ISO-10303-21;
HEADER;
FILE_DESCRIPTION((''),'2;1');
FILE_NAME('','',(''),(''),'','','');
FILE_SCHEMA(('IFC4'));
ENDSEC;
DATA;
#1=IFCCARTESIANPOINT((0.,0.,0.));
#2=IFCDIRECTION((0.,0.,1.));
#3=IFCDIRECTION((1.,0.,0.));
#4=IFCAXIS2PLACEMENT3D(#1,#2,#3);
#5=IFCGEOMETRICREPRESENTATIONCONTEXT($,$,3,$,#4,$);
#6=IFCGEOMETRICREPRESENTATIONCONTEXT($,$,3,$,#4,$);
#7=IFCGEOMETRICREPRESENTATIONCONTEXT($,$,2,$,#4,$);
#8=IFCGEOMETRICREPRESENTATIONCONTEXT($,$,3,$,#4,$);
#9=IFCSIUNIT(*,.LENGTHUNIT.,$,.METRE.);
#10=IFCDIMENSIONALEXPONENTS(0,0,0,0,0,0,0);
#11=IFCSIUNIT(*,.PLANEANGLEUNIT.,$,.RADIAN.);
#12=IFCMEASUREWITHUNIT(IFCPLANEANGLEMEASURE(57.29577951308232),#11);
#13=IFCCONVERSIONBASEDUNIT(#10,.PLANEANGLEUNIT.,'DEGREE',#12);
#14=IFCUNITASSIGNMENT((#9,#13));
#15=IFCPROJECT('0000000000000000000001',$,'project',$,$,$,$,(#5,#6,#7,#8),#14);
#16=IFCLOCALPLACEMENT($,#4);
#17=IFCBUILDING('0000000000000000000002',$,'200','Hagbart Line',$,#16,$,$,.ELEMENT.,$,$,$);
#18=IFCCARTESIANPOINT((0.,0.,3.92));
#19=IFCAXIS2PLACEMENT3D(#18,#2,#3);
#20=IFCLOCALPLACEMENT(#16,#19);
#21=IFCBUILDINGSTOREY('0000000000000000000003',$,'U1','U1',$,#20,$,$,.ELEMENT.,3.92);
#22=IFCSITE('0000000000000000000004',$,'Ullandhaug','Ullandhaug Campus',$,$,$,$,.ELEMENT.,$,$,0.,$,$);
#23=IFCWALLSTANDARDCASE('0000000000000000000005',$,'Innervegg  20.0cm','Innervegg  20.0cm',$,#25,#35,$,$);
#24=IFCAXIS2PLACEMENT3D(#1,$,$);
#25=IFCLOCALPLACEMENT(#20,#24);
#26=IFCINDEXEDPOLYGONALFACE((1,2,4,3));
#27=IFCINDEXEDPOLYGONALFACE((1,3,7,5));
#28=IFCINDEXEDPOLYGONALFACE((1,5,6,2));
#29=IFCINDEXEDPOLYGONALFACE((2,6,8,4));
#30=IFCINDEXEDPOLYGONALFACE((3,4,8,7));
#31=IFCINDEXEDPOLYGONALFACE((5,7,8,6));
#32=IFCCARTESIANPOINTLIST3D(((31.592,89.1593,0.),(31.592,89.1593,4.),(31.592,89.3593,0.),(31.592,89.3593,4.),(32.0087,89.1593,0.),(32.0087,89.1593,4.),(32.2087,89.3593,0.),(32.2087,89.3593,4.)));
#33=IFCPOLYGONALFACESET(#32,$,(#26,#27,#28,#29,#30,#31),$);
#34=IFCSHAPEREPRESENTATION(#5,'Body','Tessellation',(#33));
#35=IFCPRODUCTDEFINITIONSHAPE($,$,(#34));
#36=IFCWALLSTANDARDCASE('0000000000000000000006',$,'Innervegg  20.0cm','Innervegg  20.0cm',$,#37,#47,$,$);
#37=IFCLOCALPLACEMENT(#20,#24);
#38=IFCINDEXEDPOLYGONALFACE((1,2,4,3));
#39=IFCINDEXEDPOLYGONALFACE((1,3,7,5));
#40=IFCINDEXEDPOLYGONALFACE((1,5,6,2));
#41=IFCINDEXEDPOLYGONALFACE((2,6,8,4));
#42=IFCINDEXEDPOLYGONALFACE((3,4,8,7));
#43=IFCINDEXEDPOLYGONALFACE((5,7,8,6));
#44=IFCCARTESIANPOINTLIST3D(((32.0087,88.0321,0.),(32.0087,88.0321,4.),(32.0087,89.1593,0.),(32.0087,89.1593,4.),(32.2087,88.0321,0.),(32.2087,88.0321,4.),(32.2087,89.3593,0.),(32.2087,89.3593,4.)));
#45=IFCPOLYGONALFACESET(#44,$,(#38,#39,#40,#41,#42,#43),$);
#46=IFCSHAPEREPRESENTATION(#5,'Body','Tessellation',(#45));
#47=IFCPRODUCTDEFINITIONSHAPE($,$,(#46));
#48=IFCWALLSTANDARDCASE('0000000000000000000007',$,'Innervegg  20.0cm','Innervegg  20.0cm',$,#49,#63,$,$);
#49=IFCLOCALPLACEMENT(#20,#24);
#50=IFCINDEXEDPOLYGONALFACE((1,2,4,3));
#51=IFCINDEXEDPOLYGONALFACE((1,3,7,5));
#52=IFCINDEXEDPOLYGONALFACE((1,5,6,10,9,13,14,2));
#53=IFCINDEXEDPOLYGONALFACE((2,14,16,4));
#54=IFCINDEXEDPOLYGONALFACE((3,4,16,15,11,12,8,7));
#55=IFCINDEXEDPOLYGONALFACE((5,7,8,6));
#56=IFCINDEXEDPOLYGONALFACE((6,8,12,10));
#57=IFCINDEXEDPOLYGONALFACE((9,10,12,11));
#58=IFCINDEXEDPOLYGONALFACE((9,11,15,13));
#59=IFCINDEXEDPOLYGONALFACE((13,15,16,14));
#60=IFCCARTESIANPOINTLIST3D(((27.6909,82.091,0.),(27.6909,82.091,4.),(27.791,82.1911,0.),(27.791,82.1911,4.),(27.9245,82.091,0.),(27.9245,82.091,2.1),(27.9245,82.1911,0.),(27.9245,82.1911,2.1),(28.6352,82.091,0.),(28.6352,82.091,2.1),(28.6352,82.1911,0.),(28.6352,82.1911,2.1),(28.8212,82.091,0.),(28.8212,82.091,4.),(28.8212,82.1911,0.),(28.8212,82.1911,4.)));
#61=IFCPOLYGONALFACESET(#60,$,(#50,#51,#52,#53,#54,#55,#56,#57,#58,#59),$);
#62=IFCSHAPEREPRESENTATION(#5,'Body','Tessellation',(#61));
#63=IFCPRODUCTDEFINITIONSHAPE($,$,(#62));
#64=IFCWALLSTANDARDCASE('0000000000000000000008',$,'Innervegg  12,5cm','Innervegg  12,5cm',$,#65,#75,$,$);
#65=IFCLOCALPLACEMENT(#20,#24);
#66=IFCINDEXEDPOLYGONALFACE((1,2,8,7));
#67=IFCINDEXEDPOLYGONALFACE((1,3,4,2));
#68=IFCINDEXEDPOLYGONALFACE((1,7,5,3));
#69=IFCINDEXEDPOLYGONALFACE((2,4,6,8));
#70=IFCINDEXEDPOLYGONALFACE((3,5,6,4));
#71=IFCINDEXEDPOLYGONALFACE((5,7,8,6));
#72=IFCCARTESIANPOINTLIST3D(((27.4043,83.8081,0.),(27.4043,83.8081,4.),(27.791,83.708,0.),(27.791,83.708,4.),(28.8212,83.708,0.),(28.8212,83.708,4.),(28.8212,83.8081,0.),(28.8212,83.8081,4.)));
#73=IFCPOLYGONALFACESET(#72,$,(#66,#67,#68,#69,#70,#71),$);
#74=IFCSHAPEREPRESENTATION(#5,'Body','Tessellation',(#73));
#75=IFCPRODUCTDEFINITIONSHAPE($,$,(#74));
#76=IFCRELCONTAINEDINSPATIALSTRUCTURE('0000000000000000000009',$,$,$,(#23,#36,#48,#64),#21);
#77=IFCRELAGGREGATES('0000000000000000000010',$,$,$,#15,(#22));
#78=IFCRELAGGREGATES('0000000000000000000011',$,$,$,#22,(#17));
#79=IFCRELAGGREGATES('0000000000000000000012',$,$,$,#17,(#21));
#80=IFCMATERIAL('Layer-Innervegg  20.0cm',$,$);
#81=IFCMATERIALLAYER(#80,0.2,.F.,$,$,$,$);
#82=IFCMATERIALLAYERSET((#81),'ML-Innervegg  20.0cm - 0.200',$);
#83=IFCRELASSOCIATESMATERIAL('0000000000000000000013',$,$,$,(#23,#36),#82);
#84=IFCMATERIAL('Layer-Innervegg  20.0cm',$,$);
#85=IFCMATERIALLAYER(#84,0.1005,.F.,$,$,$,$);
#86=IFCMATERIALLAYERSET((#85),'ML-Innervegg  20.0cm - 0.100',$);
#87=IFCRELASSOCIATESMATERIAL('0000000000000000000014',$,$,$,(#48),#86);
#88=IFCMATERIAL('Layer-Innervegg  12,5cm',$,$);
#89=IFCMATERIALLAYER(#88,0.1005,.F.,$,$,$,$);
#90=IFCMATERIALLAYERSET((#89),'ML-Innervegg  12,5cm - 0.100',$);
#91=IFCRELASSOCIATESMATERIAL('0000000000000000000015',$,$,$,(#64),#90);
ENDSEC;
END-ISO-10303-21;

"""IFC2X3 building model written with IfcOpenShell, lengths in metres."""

from ifc_helpers import new_model, entity, si_unit, converted_unit, frame, origin_with_axes, place, context, project, spatial, polyline, outline, extrude, material, layer, layer_set, layer_usage, element, save


model = new_model("IFC2X3")

# Units and contexts
context_of_model_1 = context(None, 3, world=origin_with_axes())
context_of_model_2 = context(None, 3, world=origin_with_axes())
context_of_model_3 = context(None, 2, world=origin_with_axes())
context_of_model_4 = context(None, 3, world=origin_with_axes())
ifc_project = project(units=[si_unit("LENGTHUNIT", "METRE"), converted_unit("PLANEANGLEUNIT", "DEGREE", entity("IfcPlaneAngleMeasure", 57.29577951308232), si_unit("PLANEANGLEUNIT", "RADIAN"), dimensions=[0, 0, 0, 0, 0, 0, 0])], contexts=[context_of_model_1, context_of_model_2, context_of_model_3, context_of_model_4])

# Site, building, storey
site = spatial("IfcSite", under=ifc_project, Name="Ullandhaug", Description="Ullandhaug Campus", CompositionType="ELEMENT", RefElevation=0.0)
building_placement = place(None, origin_with_axes())
building = spatial("IfcBuilding", under=site, at=building_placement, Name="200", Description="Hagbart Line", CompositionType="ELEMENT")
storey_placement = place(building_placement, frame((0.0, 0.0, 3.92), z_axis=(0.0, 0.0, 1.0), x_axis=(1.0, 0.0, 0.0)))
storey = spatial("IfcBuildingStorey", under=building, at=storey_placement, Name="U1", Description="U1", CompositionType="ELEMENT", Elevation=3.92)

# Shared definitions
ifc_material_1 = material(Name="Layer-Innervegg  20.0cm")
ifc_layer_1 = layer(ifc_material_1, 0.2, ventilated=False)
ifc_layer_set_1 = layer_set([ifc_layer_1], Name="ML-Innervegg  20.0cm - 0.200")
ifc_layer_usage_1 = layer_usage(ifc_layer_set_1, "AXIS2", "POSITIVE", 0.0)

# Walls
wall_1_placement = place(storey_placement, frame((31.592, 89.1593, 0.0), z_axis=(0.0, 0.0, 1.0), x_axis=(1.0, 0.0, 0.0)))
element("IfcWallStandardCase", 1, at=wall_1_placement, inside=storey, material=ifc_layer_usage_1, Name="Innervegg  20.0cm", Description="Innervegg  20.0cm", context=context_of_model_1, shape_type="SweptSolid", body=[
    extrude(outline(polyline([(0.0, 0.0), (0.4167, 0.0), (0.6167, 0.2), (0.0, 0.2), (0.0, 0.0)])), origin_with_axes(), (0.0, 0.0, 1.0), 4.0),
])
wall_2_placement = place(storey_placement, frame((32.0087, 89.1593, 0.0), z_axis=(0.0, 0.0, 1.0), x_axis=(0.0, -1.0, 0.0)))
element("IfcWallStandardCase", 2, at=wall_2_placement, inside=storey, material=ifc_layer_usage_1, Name="Innervegg  20.0cm", Description="Innervegg  20.0cm", context=context_of_model_1, shape_type="SweptSolid", body=[
    extrude(outline(polyline([(0.0, 0.0), (1.1272, 0.0), (1.1272, 0.2), (-0.2, 0.2), (0.0, 0.0)])), frame((0.0, 0.0, 0.0), z_axis=(0.0, 0.0, 1.0), x_axis=(1.0, 0.0, 0.0)), (0.0, 0.0, 1.0), 4.0),
])

# Wall, opening
ifc_material_2 = material(Name="Layer-Innervegg  20.0cm")
ifc_layer_2 = layer(ifc_material_2, 0.1005, ventilated=False)
ifc_layer_set_2 = layer_set([ifc_layer_2], Name="ML-Innervegg  20.0cm - 0.100")
ifc_layer_usage_2 = layer_usage(ifc_layer_set_2, "AXIS2", "POSITIVE", 0.0)
wall_3_placement = place(storey_placement, frame((28.8212, 82.1911, 0.0), z_axis=(0.0, 0.0, 1.0), x_axis=(-1.0, 0.0, 0.0)))
wall_3 = element("IfcWallStandardCase", 3, at=wall_3_placement, inside=storey, material=ifc_layer_usage_2, Name="Innervegg  20.0cm", Description="Innervegg  20.0cm", context=context_of_model_1, shape_type="SweptSolid", body=[
    extrude(outline(polyline([(0.0, 0.0), (1.0302, 0.0), (1.1303, 0.1001), (0.0, 0.1001), (0.0, 0.0)])), frame((0.0, 0.0, 0.0), z_axis=(0.0, 0.0, 1.0), x_axis=(1.0, 0.0, 0.0)), (0.0, 0.0, 1.0), 4.0),
])
opening_1_placement = place(wall_3_placement, frame((0.1859, 0.1001, 0.0), z_axis=(0.0, 0.0, 1.0), x_axis=(1.0, 0.0, 0.0)))
element("IfcOpeningElement", 4, at=opening_1_placement, cuts=wall_3, context=context_of_model_1, shape_type="SweptSolid", body=[
    extrude(outline(polyline([(0.0, 0.0), (2.1, 0.0), (2.1, 0.7107), (0.0, 0.7107), (0.0, 0.0)])), frame((0.0, 0.0, 0.0), z_axis=(0.0, 1.0, 0.0), x_axis=(0.0, 0.0, 1.0)), (0.0, 0.0, -1.0), 0.1001),
])

# Wall
ifc_material_3 = material(Name="Layer-Innervegg  12,5cm")
ifc_layer_3 = layer(ifc_material_3, 0.1005, ventilated=False)
ifc_layer_set_3 = layer_set([ifc_layer_3], Name="ML-Innervegg  12,5cm - 0.100")
ifc_layer_usage_3 = layer_usage(ifc_layer_set_3, "AXIS2", "POSITIVE", 0.0)
wall_4_placement = place(storey_placement, frame((28.8212, 83.8081, 0.0), z_axis=(0.0, 0.0, 1.0), x_axis=(-1.0, 0.0, 0.0)))
element("IfcWallStandardCase", 5, at=wall_4_placement, inside=storey, material=ifc_layer_usage_3, Name="Innervegg  12,5cm", Description="Innervegg  12,5cm", context=context_of_model_1, shape_type="SweptSolid", body=[
    extrude(outline(polyline([(0.0, 0.0), (1.4169, 0.0), (1.0302, 0.1001), (0.0, 0.1001), (0.0, 0.0)])), frame((0.0, 0.0, 0.0), z_axis=(0.0, 0.0, 1.0), x_axis=(1.0, 0.0, 0.0)), (0.0, 0.0, 1.0), 4.0),
])

save(model, "model.ifc")
